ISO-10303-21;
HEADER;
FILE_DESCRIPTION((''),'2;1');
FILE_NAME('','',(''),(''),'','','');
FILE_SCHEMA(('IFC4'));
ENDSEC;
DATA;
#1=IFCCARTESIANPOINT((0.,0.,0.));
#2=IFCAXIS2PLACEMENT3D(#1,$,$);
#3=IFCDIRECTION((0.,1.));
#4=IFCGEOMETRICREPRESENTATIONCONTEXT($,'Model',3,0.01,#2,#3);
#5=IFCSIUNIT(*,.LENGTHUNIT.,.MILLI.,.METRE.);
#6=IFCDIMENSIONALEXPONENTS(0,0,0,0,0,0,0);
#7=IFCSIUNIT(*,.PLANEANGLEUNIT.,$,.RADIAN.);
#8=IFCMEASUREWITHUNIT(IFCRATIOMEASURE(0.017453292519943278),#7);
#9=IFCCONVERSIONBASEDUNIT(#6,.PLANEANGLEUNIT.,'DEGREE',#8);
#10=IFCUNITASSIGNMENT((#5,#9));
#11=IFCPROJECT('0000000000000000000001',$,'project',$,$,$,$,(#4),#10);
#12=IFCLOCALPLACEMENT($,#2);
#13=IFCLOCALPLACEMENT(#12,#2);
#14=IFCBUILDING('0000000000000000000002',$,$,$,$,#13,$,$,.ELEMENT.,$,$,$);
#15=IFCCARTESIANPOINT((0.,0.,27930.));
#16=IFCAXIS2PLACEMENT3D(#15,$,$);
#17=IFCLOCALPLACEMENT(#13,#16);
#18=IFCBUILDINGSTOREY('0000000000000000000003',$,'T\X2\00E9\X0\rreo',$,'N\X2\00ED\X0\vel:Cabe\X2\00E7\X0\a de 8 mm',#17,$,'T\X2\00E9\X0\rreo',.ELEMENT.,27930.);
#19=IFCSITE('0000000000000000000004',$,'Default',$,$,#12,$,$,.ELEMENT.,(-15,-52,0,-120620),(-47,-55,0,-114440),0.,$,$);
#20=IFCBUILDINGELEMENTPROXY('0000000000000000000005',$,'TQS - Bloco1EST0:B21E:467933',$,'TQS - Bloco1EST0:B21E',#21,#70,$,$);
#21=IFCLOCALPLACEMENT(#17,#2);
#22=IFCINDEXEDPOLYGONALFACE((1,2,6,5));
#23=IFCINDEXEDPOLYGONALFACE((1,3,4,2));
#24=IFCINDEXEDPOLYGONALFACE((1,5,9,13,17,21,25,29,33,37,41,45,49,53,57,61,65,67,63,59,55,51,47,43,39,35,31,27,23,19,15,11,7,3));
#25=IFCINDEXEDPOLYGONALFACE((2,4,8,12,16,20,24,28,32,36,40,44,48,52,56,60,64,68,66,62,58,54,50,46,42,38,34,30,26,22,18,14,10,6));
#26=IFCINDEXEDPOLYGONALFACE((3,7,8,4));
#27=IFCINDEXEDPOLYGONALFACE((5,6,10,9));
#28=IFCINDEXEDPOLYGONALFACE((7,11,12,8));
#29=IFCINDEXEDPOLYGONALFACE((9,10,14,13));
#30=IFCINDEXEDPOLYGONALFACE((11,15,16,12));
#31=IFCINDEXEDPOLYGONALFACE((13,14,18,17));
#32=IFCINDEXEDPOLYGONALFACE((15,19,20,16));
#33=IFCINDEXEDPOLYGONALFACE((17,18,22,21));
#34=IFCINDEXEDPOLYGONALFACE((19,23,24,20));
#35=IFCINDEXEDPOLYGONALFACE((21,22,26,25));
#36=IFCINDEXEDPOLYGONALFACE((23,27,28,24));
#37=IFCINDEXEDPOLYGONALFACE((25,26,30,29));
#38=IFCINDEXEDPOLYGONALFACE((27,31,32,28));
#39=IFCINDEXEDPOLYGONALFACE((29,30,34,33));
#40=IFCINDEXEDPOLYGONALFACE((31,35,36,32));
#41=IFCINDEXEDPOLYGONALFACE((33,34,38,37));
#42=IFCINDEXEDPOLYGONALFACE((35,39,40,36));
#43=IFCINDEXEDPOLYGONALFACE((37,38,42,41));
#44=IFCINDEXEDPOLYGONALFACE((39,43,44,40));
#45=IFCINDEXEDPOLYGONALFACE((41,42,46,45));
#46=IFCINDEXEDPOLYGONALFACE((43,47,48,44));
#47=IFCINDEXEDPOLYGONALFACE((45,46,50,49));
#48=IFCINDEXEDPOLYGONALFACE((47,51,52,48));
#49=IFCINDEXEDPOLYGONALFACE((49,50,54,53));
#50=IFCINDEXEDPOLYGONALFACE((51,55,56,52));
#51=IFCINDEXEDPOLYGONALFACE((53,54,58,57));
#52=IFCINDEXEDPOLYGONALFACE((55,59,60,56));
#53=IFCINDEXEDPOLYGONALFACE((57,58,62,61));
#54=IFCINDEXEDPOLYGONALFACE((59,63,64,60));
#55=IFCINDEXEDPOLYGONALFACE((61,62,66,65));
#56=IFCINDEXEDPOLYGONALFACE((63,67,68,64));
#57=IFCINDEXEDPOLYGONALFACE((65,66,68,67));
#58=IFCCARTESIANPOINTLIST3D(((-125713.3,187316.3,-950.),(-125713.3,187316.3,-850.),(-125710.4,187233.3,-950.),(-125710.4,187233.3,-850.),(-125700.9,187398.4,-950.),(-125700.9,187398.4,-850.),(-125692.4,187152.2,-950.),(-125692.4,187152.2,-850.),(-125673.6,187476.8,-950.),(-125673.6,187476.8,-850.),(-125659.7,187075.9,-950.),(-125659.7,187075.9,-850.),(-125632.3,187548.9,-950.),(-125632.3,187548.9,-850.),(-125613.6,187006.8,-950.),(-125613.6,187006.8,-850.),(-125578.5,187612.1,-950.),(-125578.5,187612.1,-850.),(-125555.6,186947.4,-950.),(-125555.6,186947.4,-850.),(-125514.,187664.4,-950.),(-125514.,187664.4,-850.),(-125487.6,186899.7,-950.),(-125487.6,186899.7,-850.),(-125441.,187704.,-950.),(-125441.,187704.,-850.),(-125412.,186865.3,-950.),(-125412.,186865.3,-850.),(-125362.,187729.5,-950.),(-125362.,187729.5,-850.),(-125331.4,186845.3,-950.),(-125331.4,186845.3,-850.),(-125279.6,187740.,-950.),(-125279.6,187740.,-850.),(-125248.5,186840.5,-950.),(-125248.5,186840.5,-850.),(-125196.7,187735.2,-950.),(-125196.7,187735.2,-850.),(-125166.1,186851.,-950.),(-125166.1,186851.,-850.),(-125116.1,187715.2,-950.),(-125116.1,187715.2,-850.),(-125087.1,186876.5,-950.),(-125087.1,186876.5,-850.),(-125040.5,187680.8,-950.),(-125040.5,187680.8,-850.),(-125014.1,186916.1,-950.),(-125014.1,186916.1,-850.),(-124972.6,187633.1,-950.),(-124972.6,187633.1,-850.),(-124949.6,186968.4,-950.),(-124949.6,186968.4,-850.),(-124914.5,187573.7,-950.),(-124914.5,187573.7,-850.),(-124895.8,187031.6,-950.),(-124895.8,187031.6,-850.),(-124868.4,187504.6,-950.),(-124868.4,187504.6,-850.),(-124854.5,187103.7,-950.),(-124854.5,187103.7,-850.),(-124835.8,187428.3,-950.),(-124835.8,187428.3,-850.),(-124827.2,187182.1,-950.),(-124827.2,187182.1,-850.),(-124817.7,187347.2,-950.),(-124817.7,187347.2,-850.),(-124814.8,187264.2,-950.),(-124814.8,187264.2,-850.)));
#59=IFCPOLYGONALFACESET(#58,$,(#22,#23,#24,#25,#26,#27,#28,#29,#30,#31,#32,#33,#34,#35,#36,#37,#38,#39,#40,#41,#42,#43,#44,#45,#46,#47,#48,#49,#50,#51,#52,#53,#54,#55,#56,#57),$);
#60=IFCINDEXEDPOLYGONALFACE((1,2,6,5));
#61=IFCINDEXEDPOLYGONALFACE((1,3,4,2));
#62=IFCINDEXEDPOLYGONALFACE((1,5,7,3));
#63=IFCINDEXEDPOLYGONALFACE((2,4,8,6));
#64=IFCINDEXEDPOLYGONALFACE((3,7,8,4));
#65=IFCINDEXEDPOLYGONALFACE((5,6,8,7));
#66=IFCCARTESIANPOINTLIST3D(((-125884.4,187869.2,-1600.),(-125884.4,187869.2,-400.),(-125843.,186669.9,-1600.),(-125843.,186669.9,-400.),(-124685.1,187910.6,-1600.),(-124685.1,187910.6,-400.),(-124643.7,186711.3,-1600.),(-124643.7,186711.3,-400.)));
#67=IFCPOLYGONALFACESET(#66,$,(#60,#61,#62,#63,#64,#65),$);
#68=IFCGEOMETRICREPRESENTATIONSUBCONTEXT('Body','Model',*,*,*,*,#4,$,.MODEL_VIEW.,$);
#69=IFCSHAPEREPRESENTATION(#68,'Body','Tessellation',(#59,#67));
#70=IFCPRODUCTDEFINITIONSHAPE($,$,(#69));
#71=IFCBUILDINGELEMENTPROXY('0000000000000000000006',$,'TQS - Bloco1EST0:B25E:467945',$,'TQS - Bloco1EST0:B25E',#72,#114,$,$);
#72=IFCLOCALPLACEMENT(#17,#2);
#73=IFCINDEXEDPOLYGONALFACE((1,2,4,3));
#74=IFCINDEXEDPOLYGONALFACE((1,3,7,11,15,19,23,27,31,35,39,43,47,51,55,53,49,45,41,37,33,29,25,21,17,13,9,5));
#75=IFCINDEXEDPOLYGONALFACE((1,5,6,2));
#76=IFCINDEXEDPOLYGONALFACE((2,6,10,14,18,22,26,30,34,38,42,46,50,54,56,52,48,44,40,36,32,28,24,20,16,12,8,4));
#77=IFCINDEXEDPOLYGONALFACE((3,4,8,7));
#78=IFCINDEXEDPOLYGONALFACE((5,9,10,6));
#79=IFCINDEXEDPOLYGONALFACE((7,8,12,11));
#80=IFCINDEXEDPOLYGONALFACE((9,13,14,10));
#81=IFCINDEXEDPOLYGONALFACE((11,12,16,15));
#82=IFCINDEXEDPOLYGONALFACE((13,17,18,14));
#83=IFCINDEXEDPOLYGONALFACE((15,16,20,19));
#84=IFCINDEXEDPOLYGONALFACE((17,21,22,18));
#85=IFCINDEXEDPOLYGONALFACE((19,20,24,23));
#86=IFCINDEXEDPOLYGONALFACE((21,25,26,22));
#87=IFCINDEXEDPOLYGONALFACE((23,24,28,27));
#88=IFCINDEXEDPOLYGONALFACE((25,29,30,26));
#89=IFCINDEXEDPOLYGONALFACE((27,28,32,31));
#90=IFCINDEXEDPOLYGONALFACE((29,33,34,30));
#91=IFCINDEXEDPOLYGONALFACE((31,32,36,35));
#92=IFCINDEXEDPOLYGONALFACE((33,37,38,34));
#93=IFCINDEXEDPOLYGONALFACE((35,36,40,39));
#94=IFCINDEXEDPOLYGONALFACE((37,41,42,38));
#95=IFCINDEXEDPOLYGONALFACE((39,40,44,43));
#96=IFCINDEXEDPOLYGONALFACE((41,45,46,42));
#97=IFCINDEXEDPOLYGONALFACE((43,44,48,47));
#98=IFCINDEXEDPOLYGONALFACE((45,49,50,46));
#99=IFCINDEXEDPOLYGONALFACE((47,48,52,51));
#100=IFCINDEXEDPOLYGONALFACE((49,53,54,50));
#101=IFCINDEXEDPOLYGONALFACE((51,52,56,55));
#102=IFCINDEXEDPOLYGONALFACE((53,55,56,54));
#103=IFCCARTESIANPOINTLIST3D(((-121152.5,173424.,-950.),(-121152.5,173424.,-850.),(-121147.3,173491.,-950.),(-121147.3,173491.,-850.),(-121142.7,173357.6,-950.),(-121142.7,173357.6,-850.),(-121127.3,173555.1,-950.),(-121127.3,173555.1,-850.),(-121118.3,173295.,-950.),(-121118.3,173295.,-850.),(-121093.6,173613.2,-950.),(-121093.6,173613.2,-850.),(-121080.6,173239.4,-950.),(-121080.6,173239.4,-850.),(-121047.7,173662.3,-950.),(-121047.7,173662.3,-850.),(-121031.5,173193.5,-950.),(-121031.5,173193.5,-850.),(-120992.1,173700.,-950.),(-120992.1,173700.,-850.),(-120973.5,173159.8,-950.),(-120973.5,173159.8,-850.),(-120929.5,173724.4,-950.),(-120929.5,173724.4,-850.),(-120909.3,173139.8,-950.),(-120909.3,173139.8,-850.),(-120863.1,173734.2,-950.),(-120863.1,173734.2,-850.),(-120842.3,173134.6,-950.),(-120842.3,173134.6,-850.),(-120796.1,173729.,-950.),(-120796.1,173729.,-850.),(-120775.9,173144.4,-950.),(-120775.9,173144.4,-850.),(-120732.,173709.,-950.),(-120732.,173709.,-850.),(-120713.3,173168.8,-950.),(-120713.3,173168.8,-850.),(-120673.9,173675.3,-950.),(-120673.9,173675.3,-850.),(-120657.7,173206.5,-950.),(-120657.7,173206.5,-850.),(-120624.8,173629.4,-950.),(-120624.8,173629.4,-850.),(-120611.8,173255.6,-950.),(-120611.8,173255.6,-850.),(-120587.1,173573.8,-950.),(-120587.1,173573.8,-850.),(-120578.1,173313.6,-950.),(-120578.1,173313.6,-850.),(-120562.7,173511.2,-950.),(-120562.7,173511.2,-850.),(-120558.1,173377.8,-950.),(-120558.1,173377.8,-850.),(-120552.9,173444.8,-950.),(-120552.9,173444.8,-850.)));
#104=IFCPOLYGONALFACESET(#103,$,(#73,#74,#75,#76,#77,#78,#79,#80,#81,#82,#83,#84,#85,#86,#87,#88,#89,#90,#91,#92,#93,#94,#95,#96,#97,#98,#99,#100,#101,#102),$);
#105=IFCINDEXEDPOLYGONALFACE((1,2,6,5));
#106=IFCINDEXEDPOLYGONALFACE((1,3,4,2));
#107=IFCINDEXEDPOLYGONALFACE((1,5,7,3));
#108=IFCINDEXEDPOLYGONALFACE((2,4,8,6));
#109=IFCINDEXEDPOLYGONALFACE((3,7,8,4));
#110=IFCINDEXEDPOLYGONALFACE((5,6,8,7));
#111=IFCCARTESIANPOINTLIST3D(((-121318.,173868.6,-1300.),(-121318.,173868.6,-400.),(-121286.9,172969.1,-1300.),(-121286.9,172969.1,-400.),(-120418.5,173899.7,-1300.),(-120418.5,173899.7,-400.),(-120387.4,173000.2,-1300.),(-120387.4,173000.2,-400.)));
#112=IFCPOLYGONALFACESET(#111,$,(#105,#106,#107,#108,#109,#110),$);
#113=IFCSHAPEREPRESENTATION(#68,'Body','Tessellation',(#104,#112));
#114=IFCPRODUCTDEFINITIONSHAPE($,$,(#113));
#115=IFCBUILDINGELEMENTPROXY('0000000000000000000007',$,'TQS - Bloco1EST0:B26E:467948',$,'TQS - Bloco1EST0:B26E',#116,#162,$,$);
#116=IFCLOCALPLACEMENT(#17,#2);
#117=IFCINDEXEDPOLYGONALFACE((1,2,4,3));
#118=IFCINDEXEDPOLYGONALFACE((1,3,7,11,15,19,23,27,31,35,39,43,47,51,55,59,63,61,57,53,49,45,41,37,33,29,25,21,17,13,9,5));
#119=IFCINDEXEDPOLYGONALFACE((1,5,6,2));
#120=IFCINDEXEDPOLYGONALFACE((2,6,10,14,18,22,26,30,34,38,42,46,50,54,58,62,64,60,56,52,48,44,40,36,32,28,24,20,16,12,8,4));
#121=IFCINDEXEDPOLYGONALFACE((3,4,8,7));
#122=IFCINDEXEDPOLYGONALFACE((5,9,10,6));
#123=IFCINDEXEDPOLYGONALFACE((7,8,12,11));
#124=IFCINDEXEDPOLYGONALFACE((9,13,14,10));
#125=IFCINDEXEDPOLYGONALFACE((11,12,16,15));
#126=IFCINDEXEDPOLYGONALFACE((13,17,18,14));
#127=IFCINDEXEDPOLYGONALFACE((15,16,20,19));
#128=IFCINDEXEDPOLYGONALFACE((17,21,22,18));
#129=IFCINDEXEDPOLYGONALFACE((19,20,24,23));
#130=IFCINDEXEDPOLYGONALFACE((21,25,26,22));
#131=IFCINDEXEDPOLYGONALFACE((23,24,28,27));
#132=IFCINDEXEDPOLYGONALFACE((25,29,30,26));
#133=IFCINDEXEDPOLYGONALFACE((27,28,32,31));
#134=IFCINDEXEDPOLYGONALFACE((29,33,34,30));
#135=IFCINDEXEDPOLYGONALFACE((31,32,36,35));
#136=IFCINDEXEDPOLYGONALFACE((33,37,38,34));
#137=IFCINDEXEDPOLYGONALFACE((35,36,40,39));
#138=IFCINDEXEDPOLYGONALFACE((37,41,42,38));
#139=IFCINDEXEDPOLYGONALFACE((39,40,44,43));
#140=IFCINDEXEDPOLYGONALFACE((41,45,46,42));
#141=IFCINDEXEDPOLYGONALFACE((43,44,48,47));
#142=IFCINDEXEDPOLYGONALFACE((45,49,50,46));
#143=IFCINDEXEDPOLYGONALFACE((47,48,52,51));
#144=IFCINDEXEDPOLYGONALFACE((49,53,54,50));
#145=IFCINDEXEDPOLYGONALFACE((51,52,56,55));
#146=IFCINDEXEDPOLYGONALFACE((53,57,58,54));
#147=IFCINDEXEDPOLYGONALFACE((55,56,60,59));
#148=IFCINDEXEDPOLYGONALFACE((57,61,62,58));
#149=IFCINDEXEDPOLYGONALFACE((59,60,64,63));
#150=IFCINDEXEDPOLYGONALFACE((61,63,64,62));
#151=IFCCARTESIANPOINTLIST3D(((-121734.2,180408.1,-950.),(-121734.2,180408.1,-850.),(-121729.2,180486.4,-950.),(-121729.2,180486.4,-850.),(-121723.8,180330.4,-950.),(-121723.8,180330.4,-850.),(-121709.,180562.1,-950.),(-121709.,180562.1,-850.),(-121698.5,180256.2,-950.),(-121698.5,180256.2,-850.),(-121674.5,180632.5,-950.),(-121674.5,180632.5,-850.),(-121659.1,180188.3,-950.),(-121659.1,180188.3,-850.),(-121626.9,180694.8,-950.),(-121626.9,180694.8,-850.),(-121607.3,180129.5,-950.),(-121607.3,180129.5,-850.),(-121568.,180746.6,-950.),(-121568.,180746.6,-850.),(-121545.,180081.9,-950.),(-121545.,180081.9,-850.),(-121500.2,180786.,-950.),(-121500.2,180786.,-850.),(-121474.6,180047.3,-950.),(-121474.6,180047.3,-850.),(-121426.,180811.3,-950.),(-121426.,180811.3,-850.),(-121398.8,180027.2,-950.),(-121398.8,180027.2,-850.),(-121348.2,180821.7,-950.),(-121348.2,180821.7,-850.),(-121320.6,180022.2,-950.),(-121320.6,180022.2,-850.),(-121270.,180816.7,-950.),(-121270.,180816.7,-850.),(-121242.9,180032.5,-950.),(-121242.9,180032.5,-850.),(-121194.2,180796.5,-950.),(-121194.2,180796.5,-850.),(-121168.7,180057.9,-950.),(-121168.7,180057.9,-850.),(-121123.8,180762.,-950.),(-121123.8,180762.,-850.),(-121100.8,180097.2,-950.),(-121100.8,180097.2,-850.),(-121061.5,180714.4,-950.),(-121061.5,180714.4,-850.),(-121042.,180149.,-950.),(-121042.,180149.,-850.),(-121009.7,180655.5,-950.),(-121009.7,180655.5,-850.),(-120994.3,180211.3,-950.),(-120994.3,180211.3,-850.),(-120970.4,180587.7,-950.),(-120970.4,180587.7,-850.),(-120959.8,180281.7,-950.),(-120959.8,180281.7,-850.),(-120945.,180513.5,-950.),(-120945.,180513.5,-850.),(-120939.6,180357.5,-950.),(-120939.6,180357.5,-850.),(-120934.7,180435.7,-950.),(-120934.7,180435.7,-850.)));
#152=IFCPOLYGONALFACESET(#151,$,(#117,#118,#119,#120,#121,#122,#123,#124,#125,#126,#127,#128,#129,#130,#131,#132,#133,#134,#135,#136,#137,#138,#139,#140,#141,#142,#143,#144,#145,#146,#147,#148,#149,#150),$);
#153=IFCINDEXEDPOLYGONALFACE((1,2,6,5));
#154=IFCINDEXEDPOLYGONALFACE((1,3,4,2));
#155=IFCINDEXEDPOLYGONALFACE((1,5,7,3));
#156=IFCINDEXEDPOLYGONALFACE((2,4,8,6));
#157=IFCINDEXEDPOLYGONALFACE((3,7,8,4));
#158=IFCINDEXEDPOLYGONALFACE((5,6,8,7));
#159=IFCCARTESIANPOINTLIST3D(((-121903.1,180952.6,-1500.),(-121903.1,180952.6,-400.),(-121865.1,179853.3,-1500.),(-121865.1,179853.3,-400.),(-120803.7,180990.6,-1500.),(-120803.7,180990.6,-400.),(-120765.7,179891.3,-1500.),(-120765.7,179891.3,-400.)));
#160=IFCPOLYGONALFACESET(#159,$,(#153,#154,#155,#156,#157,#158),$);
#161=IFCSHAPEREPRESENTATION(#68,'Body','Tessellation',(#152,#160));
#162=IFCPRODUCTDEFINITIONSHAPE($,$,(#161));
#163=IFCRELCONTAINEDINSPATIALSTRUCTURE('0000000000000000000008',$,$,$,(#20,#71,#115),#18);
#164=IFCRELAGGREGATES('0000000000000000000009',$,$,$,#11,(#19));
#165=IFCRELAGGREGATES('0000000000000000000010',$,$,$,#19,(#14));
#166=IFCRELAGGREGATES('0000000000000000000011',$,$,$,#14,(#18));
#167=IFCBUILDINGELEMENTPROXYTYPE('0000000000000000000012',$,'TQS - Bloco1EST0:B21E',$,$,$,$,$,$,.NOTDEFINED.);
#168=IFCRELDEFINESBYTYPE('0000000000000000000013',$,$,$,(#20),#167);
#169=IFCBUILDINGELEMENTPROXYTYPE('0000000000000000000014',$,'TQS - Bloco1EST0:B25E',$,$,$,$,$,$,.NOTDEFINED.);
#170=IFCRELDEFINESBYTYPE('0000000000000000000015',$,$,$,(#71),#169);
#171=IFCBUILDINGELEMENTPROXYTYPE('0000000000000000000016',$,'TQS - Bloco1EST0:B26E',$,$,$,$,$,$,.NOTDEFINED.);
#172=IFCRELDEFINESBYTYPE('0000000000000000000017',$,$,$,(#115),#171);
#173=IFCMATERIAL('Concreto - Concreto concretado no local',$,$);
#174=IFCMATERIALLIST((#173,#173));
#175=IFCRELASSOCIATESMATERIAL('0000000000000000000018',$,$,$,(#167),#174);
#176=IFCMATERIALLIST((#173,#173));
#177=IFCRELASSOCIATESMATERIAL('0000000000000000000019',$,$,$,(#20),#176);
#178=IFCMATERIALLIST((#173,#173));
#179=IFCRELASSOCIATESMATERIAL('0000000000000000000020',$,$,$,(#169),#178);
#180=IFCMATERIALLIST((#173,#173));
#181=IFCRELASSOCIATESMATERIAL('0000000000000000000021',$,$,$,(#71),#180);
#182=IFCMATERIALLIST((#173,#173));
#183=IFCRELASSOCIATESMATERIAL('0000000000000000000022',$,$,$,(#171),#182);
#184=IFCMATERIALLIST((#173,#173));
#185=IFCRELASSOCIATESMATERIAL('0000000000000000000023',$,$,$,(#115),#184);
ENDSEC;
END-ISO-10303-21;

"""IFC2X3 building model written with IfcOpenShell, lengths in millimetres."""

from ifc_helpers import new_model, entity, si_unit, converted_unit, direction, frame, frame_2d, origin, origin_2d_with_axis, place, context, subcontext, project, spatial, rectangle, circle, extrude, source, transform, mapped, material, material_list, type_object, type_shapes, element, save


model = new_model("IFC2X3")

# Units and contexts
model_context = context("Model", 3, precision=0.01, world=origin(), true_north=direction((0.0, 1.0)))
body_context = subcontext(model_context, "Body", "Model", "MODEL_VIEW")
ifc_project = project(units=[si_unit("LENGTHUNIT", "METRE", prefix="MILLI"), converted_unit("PLANEANGLEUNIT", "DEGREE", entity("IfcRatioMeasure", 0.017453292519943278), si_unit("PLANEANGLEUNIT", "RADIAN"), dimensions=[0, 0, 0, 0, 0, 0, 0])], contexts=[model_context])

# Site, building, storey
site_placement = place(None, origin())
site = spatial("IfcSite", under=ifc_project, at=site_placement, Name="Default", CompositionType="ELEMENT", RefLatitude=(-15, -52, 0, -120620), RefLongitude=(-47, -55, 0, -114440), RefElevation=0.0)
building_placement = place(site_placement, origin())
building = spatial("IfcBuilding", under=site, at=building_placement, CompositionType="ELEMENT")
storey_placement = place(building_placement, frame((0.0, 0.0, 27930.0)))
storey = spatial("IfcBuildingStorey", under=building, at=storey_placement, Name="Térreo", ObjectType="Nível:Cabeça de 8 mm", LongName="Térreo", CompositionType="ELEMENT", Elevation=27930.0)

# Building element proxies
ifc_material_1 = material(Name="Concreto - Concreto concretado no local")
ifc_material_list_1 = material_list([ifc_material_1, ifc_material_1])
ifc_material_list_2 = material_list([ifc_material_1, ifc_material_1])
building_element_proxy_type_1 = type_object("IfcBuildingElementProxyType", Name="TQS - Bloco1EST0:B21E", PredefinedType="NOTDEFINED", material=ifc_material_list_2)
shared_shape_1 = source(origin(), body_context, "Body", "SweptSolid", [
    extrude(circle(Radius=450.0, at=frame_2d((0.0, 0.0), x_axis=(1.0, 0.0))), frame((0.0, 0.0, -550.0)), (0.0, 0.0, 1.0), 100.0),
    extrude(rectangle(XDim=1200.0, YDim=1200.0, at=origin_2d_with_axis()), frame((0.0, 0.0, -1200.0), z_axis=(0.0, 0.0, 1.0), x_axis=(-1.0, 0.0, 0.0)), (0.0, 0.0, 1.0), 1200.0),
])
type_shapes(building_element_proxy_type_1, [shared_shape_1])
proxy_1_placement = place(storey_placement, frame((-125264.1, 187290.3, -400.0), z_axis=(0.0, 0.0, 1.0), x_axis=(-0.034551, 0.999403, 0.0)))
element("IfcBuildingElementProxy", 1, at=proxy_1_placement, inside=storey, type_object=building_element_proxy_type_1, material=ifc_material_list_1, Name="TQS - Bloco1EST0:B21E:467933", ObjectType="TQS - Bloco1EST0:B21E", context=body_context, shape_type="MappedRepresentation", body=[
    mapped(shared_shape_1, transform((0.0, 0.0, 0.0), scale=1.0)),
])
ifc_material_list_3 = material_list([ifc_material_1, ifc_material_1])
ifc_material_list_4 = material_list([ifc_material_1, ifc_material_1])
building_element_proxy_type_2 = type_object("IfcBuildingElementProxyType", Name="TQS - Bloco1EST0:B25E", PredefinedType="NOTDEFINED", material=ifc_material_list_4)
shared_shape_2 = source(origin(), body_context, "Body", "SweptSolid", [
    extrude(circle(Radius=300.0, at=frame_2d((0.0, 0.0), x_axis=(1.0, 0.0))), frame((0.0, 0.0, -550.0)), (0.0, 0.0, 1.0), 100.0),
    extrude(rectangle(XDim=900.0, YDim=900.0, at=origin_2d_with_axis()), frame((0.0, 0.0, -900.0), z_axis=(0.0, 0.0, 1.0), x_axis=(-1.0, 0.0, 0.0)), (0.0, 0.0, 1.0), 900.0),
])
type_shapes(building_element_proxy_type_2, [shared_shape_2])
proxy_2_placement = place(storey_placement, frame((-120852.7, 173434.4, -400.0), z_axis=(0.0, 0.0, 1.0), x_axis=(-0.034551, 0.999403, 0.0)))
element("IfcBuildingElementProxy", 2, at=proxy_2_placement, inside=storey, type_object=building_element_proxy_type_2, material=ifc_material_list_3, Name="TQS - Bloco1EST0:B25E:467945", ObjectType="TQS - Bloco1EST0:B25E", context=body_context, shape_type="MappedRepresentation", body=[
    mapped(shared_shape_2, transform((0.0, 0.0, 0.0), scale=1.0)),
])
ifc_material_list_5 = material_list([ifc_material_1, ifc_material_1])
ifc_material_list_6 = material_list([ifc_material_1, ifc_material_1])
building_element_proxy_type_3 = type_object("IfcBuildingElementProxyType", Name="TQS - Bloco1EST0:B26E", PredefinedType="NOTDEFINED", material=ifc_material_list_6)
shared_shape_3 = source(origin(), body_context, "Body", "SweptSolid", [
    extrude(circle(Radius=400.0, at=frame_2d((0.0, 0.0), x_axis=(1.0, 0.0))), frame((0.0, 0.0, -550.0)), (0.0, 0.0, 1.0), 100.0),
    extrude(rectangle(XDim=1100.0, YDim=1100.0, at=origin_2d_with_axis()), frame((0.0, 0.0, -1100.0), z_axis=(0.0, 0.0, 1.0), x_axis=(-1.0, 0.0, 0.0)), (0.0, 0.0, 1.0), 1100.0),
])
type_shapes(building_element_proxy_type_3, [shared_shape_3])
proxy_3_placement = place(storey_placement, frame((-121334.4, 180421.9, -400.0), z_axis=(0.0, 0.0, 1.0), x_axis=(-0.034551, 0.999403, 0.0)))
element("IfcBuildingElementProxy", 3, at=proxy_3_placement, inside=storey, type_object=building_element_proxy_type_3, material=ifc_material_list_5, Name="TQS - Bloco1EST0:B26E:467948", ObjectType="TQS - Bloco1EST0:B26E", context=body_context, shape_type="MappedRepresentation", body=[
    mapped(shared_shape_3, transform((0.0, 0.0, 0.0), scale=1.0)),
])

save(model, "model.ifc")
